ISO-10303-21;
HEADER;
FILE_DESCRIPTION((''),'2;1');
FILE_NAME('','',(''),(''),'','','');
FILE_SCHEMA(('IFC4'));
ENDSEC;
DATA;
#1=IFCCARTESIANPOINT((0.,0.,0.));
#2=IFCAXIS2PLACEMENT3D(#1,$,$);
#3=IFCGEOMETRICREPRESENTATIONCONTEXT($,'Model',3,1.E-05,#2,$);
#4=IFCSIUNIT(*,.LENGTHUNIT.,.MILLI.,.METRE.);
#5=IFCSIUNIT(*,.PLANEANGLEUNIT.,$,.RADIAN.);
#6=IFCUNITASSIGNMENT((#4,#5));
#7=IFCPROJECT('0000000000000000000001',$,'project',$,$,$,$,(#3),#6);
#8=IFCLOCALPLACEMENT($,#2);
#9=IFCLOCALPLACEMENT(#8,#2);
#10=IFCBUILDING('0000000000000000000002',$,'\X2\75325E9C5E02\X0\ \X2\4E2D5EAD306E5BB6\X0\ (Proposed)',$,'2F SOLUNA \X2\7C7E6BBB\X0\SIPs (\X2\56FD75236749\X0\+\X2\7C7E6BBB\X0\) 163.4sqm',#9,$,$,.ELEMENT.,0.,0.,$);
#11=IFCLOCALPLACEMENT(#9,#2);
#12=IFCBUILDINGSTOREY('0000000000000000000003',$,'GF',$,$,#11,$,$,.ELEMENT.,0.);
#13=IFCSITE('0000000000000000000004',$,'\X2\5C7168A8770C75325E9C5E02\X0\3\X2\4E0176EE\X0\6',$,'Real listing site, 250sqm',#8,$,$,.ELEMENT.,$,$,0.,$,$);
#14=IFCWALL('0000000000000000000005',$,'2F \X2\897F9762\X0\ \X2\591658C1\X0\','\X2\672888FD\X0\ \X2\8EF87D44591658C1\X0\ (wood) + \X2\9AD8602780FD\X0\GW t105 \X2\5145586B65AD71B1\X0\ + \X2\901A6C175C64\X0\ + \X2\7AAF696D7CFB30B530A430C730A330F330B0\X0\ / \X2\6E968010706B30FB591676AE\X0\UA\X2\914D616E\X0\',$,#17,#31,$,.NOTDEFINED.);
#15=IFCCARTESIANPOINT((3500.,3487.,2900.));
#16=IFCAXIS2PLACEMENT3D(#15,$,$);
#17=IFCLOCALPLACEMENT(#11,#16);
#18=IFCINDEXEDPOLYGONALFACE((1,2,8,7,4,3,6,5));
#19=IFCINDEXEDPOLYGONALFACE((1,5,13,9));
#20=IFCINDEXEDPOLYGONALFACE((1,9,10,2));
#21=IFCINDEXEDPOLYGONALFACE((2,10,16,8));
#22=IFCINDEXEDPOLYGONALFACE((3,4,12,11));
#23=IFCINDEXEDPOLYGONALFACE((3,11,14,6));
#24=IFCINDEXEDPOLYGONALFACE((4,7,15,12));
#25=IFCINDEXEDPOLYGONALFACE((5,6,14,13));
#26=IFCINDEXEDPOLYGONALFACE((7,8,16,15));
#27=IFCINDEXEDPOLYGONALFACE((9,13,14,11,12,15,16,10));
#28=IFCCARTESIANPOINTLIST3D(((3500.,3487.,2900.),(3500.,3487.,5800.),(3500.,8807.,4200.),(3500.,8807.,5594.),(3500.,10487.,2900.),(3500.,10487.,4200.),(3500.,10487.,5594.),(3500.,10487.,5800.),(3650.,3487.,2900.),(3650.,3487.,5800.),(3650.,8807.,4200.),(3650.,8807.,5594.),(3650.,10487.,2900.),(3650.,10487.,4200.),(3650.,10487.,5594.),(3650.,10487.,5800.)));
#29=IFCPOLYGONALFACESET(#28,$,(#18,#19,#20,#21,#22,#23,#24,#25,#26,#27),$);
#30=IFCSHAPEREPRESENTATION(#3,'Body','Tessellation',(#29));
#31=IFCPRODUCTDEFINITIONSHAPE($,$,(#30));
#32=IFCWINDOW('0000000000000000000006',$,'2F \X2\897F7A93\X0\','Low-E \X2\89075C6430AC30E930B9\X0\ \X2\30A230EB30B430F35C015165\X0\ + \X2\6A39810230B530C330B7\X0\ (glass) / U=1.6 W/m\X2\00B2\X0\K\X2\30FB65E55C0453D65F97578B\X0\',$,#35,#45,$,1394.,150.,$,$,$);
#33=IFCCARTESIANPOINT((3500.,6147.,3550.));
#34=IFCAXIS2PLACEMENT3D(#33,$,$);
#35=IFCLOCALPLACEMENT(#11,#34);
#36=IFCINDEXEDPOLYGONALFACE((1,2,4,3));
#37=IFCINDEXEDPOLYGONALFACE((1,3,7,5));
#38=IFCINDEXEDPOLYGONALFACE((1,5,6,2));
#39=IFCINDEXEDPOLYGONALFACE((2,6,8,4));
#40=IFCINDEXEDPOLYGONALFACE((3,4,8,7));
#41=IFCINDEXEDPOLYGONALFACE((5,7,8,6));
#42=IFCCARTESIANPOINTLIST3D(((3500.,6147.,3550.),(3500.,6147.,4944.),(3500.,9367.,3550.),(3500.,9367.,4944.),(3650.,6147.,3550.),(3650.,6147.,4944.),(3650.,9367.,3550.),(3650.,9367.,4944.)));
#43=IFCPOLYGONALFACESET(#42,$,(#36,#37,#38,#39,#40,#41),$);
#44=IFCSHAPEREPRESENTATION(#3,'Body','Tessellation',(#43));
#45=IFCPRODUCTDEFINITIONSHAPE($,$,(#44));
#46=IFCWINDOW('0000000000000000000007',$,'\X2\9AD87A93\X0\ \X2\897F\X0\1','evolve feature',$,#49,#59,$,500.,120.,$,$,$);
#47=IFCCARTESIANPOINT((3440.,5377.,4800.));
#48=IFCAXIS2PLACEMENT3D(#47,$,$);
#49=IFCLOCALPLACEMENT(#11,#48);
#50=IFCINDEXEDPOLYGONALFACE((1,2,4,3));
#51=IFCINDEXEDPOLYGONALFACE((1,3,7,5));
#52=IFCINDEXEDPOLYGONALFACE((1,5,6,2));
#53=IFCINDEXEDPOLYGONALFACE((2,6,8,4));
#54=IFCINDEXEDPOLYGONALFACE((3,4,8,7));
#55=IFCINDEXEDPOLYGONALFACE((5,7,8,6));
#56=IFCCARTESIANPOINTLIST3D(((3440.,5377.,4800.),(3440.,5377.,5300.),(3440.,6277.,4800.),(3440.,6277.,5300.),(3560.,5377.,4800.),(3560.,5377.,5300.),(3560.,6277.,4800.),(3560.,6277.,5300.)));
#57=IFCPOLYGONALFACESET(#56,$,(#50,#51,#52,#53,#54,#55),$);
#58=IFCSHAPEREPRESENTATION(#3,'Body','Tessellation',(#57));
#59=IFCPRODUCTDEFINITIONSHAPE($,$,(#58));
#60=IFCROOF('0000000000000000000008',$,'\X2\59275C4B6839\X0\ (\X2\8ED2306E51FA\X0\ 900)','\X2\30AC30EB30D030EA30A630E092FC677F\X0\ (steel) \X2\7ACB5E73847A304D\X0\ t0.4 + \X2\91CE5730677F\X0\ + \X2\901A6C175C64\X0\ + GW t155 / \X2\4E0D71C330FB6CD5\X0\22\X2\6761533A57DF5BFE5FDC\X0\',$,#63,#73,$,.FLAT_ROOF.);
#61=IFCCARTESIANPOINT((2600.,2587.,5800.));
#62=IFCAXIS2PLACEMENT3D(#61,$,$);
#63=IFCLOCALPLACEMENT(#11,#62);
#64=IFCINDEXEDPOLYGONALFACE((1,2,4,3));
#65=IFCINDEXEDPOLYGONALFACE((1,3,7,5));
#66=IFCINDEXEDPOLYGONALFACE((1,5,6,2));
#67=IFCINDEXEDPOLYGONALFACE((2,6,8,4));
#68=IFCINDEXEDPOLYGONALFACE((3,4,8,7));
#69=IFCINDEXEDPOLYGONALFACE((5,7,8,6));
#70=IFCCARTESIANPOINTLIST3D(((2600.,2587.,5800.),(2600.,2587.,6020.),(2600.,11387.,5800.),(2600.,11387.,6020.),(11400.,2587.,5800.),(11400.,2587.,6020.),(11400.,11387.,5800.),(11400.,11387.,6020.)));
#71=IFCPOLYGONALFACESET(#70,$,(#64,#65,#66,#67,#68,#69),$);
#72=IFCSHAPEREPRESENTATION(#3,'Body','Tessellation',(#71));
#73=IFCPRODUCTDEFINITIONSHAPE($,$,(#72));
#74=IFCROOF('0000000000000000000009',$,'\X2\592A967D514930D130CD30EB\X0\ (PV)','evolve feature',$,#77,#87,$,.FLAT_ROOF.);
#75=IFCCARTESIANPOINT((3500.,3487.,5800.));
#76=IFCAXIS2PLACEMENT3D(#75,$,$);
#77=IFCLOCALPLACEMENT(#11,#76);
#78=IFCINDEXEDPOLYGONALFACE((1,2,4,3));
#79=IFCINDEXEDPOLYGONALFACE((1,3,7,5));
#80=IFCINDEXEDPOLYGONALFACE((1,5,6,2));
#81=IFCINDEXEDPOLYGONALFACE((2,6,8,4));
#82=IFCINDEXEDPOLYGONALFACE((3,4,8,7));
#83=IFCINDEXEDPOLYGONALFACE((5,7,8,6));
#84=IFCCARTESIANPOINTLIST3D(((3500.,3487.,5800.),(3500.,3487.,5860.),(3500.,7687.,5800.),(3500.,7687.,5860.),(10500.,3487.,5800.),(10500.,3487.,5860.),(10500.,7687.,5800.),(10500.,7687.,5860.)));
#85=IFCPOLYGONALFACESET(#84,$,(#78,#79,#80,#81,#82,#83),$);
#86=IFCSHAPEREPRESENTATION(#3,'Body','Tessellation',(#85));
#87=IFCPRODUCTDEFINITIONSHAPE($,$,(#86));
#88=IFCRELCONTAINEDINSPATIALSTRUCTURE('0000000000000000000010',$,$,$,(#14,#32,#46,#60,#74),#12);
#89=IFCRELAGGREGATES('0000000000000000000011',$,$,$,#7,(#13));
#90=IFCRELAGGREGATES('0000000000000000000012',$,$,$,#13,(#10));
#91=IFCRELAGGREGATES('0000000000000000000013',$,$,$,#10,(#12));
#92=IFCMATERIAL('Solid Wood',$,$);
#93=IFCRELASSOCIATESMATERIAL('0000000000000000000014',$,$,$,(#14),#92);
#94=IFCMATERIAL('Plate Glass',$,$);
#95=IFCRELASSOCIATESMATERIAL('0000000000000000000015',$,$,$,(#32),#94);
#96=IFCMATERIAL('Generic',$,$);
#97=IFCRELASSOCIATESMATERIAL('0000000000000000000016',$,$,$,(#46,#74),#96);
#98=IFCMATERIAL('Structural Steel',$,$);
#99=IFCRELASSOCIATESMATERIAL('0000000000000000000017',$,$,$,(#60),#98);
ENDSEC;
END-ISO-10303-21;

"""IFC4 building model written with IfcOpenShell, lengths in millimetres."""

from ifc_helpers import new_model, si_unit, frame, frame_2d, origin, place, context, project, spatial, rectangle, extrude, material, element, fill, save


model = new_model("IFC4")

# Units and contexts
model_context = context("Model", 3, precision=1e-05, world=origin())
ifc_project = project(units=[si_unit("LENGTHUNIT", "METRE", prefix="MILLI"), si_unit("PLANEANGLEUNIT", "RADIAN")], contexts=[model_context])

# Site, building, storey
site_placement = place(None, origin())
site = spatial("IfcSite", under=ifc_project, at=site_placement, Name="山梨県甲府市3丁目6", ObjectType="Real listing site, 250sqm", CompositionType="ELEMENT", RefElevation=0.0)
building_placement = place(site_placement, origin())
building = spatial("IfcBuilding", under=site, at=building_placement, Name="甲府市 中庭の家 (Proposed)", ObjectType="2F SOLUNA 籾殻SIPs (国産杉+籾殻) 163.4sqm", CompositionType="ELEMENT", ElevationOfRefHeight=0.0, ElevationOfTerrain=0.0)
storey_placement = place(building_placement, origin())
storey = spatial("IfcBuildingStorey", under=building, at=storey_placement, Name="GF", CompositionType="ELEMENT", Elevation=0.0)

# Shared definitions
ifc_material_1 = material(Name="Solid Wood")
ifc_material_2 = material(Name="Generic")

# Shared definitions
ifc_material_3 = material(Name="Plate Glass")

# Wall, openings, windows
wall_1_placement = place(storey_placement, frame((3500.0, 3487.0, 2900.0)))
wall_1 = element("IfcWall", 1, at=wall_1_placement, inside=storey, material=ifc_material_1, Name="2F 西面 外壁", Description="木製 軸組外壁 (wood) + 高性能GW t105 充填断熱 + 通気層 + 窯業系サイディング / 準耐火・外皮UA配慮", PredefinedType="NOTDEFINED", context=model_context, shape_type="SweptSolid", body=[
    extrude(rectangle(XDim=150.0, YDim=7000.0, at=frame_2d((75.0, 3500.0))), frame((3500.0, 3487.0, 2900.0)), (0.0, 0.0, 1.0), 2900.0),
])
opening_1_placement = place(storey_placement, frame((3500.0, 6147.0, 3550.0)))
opening_1 = element("IfcOpeningElement", 2, at=opening_1_placement, cuts=wall_1, PredefinedType="NOTDEFINED", context=model_context, shape_type="SweptSolid", body=[
    extrude(rectangle(XDim=150.0, YDim=3220.0, at=frame_2d((75.0, 1610.0))), frame((3500.0, 6147.0, 3550.0)), (0.0, 0.0, 1.0), 1394.0),
])
opening_2_placement = place(storey_placement, frame((3440.0, 5377.0, 4800.0)))
opening_2 = element("IfcOpeningElement", 3, at=opening_2_placement, cuts=wall_1, PredefinedType="NOTDEFINED", context=model_context, shape_type="SweptSolid", body=[
    extrude(rectangle(XDim=120.0, YDim=900.0, at=frame_2d((60.0, 450.0))), frame((3440.0, 5377.0, 4800.0)), (0.0, 0.0, 1.0), 500.0),
])
window_1_placement = place(storey_placement, frame((3500.0, 6147.0, 3550.0)))
window_1 = element("IfcWindow", 4, at=window_1_placement, inside=storey, material=ifc_material_3, Name="2F 西窓", Description="Low-E 複層ガラス アルゴン封入 + 樹脂サッシ (glass) / U=1.6 W/m²K・日射取得型", OverallHeight=1394.0, OverallWidth=150.0, context=model_context, shape_type="SweptSolid", body=[
    extrude(rectangle(XDim=150.0, YDim=3220.0, at=frame_2d((75.0, 1610.0))), frame((3500.0, 6147.0, 3550.0)), (0.0, 0.0, 1.0), 1394.0),
])
fill(opening_1, window_1)
window_2_placement = place(storey_placement, frame((3440.0, 5377.0, 4800.0)))
window_2 = element("IfcWindow", 5, at=window_2_placement, inside=storey, material=ifc_material_2, Name="高窓 西1", Description="evolve feature", OverallHeight=500.0, OverallWidth=120.0, context=model_context, shape_type="SweptSolid", body=[
    extrude(rectangle(XDim=120.0, YDim=900.0, at=frame_2d((60.0, 450.0))), frame((3440.0, 5377.0, 4800.0)), (0.0, 0.0, 1.0), 500.0),
])
fill(opening_2, window_2)

# Roofs
ifc_material_4 = material(Name="Structural Steel")
roof_1_placement = place(storey_placement, frame((2600.0, 2587.0, 5800.0)))
element("IfcRoof", 6, at=roof_1_placement, inside=storey, material=ifc_material_4, Name="大屋根 (軒の出 900)", Description="ガルバリウム鋼板 (steel) 立平葺き t0.4 + 野地板 + 通気層 + GW t155 / 不燃・法22条区域対応", PredefinedType="FLAT_ROOF", context=model_context, shape_type="SweptSolid", body=[
    extrude(rectangle(XDim=8800.0, YDim=8800.0, at=frame_2d((4400.0, 4400.0))), frame((2600.0, 2587.0, 5800.0)), (0.0, 0.0, 1.0), 220.0),
])
roof_2_placement = place(storey_placement, frame((3500.0, 3487.0, 5800.0)))
element("IfcRoof", 7, at=roof_2_placement, inside=storey, material=ifc_material_2, Name="太陽光パネル (PV)", Description="evolve feature", PredefinedType="FLAT_ROOF", context=model_context, shape_type="SweptSolid", body=[
    extrude(rectangle(XDim=7000.0, YDim=4200.0, at=frame_2d((3500.0, 2100.0))), frame((3500.0, 3487.0, 5800.0)), (0.0, 0.0, 1.0), 60.0),
])

save(model, "model.ifc")
